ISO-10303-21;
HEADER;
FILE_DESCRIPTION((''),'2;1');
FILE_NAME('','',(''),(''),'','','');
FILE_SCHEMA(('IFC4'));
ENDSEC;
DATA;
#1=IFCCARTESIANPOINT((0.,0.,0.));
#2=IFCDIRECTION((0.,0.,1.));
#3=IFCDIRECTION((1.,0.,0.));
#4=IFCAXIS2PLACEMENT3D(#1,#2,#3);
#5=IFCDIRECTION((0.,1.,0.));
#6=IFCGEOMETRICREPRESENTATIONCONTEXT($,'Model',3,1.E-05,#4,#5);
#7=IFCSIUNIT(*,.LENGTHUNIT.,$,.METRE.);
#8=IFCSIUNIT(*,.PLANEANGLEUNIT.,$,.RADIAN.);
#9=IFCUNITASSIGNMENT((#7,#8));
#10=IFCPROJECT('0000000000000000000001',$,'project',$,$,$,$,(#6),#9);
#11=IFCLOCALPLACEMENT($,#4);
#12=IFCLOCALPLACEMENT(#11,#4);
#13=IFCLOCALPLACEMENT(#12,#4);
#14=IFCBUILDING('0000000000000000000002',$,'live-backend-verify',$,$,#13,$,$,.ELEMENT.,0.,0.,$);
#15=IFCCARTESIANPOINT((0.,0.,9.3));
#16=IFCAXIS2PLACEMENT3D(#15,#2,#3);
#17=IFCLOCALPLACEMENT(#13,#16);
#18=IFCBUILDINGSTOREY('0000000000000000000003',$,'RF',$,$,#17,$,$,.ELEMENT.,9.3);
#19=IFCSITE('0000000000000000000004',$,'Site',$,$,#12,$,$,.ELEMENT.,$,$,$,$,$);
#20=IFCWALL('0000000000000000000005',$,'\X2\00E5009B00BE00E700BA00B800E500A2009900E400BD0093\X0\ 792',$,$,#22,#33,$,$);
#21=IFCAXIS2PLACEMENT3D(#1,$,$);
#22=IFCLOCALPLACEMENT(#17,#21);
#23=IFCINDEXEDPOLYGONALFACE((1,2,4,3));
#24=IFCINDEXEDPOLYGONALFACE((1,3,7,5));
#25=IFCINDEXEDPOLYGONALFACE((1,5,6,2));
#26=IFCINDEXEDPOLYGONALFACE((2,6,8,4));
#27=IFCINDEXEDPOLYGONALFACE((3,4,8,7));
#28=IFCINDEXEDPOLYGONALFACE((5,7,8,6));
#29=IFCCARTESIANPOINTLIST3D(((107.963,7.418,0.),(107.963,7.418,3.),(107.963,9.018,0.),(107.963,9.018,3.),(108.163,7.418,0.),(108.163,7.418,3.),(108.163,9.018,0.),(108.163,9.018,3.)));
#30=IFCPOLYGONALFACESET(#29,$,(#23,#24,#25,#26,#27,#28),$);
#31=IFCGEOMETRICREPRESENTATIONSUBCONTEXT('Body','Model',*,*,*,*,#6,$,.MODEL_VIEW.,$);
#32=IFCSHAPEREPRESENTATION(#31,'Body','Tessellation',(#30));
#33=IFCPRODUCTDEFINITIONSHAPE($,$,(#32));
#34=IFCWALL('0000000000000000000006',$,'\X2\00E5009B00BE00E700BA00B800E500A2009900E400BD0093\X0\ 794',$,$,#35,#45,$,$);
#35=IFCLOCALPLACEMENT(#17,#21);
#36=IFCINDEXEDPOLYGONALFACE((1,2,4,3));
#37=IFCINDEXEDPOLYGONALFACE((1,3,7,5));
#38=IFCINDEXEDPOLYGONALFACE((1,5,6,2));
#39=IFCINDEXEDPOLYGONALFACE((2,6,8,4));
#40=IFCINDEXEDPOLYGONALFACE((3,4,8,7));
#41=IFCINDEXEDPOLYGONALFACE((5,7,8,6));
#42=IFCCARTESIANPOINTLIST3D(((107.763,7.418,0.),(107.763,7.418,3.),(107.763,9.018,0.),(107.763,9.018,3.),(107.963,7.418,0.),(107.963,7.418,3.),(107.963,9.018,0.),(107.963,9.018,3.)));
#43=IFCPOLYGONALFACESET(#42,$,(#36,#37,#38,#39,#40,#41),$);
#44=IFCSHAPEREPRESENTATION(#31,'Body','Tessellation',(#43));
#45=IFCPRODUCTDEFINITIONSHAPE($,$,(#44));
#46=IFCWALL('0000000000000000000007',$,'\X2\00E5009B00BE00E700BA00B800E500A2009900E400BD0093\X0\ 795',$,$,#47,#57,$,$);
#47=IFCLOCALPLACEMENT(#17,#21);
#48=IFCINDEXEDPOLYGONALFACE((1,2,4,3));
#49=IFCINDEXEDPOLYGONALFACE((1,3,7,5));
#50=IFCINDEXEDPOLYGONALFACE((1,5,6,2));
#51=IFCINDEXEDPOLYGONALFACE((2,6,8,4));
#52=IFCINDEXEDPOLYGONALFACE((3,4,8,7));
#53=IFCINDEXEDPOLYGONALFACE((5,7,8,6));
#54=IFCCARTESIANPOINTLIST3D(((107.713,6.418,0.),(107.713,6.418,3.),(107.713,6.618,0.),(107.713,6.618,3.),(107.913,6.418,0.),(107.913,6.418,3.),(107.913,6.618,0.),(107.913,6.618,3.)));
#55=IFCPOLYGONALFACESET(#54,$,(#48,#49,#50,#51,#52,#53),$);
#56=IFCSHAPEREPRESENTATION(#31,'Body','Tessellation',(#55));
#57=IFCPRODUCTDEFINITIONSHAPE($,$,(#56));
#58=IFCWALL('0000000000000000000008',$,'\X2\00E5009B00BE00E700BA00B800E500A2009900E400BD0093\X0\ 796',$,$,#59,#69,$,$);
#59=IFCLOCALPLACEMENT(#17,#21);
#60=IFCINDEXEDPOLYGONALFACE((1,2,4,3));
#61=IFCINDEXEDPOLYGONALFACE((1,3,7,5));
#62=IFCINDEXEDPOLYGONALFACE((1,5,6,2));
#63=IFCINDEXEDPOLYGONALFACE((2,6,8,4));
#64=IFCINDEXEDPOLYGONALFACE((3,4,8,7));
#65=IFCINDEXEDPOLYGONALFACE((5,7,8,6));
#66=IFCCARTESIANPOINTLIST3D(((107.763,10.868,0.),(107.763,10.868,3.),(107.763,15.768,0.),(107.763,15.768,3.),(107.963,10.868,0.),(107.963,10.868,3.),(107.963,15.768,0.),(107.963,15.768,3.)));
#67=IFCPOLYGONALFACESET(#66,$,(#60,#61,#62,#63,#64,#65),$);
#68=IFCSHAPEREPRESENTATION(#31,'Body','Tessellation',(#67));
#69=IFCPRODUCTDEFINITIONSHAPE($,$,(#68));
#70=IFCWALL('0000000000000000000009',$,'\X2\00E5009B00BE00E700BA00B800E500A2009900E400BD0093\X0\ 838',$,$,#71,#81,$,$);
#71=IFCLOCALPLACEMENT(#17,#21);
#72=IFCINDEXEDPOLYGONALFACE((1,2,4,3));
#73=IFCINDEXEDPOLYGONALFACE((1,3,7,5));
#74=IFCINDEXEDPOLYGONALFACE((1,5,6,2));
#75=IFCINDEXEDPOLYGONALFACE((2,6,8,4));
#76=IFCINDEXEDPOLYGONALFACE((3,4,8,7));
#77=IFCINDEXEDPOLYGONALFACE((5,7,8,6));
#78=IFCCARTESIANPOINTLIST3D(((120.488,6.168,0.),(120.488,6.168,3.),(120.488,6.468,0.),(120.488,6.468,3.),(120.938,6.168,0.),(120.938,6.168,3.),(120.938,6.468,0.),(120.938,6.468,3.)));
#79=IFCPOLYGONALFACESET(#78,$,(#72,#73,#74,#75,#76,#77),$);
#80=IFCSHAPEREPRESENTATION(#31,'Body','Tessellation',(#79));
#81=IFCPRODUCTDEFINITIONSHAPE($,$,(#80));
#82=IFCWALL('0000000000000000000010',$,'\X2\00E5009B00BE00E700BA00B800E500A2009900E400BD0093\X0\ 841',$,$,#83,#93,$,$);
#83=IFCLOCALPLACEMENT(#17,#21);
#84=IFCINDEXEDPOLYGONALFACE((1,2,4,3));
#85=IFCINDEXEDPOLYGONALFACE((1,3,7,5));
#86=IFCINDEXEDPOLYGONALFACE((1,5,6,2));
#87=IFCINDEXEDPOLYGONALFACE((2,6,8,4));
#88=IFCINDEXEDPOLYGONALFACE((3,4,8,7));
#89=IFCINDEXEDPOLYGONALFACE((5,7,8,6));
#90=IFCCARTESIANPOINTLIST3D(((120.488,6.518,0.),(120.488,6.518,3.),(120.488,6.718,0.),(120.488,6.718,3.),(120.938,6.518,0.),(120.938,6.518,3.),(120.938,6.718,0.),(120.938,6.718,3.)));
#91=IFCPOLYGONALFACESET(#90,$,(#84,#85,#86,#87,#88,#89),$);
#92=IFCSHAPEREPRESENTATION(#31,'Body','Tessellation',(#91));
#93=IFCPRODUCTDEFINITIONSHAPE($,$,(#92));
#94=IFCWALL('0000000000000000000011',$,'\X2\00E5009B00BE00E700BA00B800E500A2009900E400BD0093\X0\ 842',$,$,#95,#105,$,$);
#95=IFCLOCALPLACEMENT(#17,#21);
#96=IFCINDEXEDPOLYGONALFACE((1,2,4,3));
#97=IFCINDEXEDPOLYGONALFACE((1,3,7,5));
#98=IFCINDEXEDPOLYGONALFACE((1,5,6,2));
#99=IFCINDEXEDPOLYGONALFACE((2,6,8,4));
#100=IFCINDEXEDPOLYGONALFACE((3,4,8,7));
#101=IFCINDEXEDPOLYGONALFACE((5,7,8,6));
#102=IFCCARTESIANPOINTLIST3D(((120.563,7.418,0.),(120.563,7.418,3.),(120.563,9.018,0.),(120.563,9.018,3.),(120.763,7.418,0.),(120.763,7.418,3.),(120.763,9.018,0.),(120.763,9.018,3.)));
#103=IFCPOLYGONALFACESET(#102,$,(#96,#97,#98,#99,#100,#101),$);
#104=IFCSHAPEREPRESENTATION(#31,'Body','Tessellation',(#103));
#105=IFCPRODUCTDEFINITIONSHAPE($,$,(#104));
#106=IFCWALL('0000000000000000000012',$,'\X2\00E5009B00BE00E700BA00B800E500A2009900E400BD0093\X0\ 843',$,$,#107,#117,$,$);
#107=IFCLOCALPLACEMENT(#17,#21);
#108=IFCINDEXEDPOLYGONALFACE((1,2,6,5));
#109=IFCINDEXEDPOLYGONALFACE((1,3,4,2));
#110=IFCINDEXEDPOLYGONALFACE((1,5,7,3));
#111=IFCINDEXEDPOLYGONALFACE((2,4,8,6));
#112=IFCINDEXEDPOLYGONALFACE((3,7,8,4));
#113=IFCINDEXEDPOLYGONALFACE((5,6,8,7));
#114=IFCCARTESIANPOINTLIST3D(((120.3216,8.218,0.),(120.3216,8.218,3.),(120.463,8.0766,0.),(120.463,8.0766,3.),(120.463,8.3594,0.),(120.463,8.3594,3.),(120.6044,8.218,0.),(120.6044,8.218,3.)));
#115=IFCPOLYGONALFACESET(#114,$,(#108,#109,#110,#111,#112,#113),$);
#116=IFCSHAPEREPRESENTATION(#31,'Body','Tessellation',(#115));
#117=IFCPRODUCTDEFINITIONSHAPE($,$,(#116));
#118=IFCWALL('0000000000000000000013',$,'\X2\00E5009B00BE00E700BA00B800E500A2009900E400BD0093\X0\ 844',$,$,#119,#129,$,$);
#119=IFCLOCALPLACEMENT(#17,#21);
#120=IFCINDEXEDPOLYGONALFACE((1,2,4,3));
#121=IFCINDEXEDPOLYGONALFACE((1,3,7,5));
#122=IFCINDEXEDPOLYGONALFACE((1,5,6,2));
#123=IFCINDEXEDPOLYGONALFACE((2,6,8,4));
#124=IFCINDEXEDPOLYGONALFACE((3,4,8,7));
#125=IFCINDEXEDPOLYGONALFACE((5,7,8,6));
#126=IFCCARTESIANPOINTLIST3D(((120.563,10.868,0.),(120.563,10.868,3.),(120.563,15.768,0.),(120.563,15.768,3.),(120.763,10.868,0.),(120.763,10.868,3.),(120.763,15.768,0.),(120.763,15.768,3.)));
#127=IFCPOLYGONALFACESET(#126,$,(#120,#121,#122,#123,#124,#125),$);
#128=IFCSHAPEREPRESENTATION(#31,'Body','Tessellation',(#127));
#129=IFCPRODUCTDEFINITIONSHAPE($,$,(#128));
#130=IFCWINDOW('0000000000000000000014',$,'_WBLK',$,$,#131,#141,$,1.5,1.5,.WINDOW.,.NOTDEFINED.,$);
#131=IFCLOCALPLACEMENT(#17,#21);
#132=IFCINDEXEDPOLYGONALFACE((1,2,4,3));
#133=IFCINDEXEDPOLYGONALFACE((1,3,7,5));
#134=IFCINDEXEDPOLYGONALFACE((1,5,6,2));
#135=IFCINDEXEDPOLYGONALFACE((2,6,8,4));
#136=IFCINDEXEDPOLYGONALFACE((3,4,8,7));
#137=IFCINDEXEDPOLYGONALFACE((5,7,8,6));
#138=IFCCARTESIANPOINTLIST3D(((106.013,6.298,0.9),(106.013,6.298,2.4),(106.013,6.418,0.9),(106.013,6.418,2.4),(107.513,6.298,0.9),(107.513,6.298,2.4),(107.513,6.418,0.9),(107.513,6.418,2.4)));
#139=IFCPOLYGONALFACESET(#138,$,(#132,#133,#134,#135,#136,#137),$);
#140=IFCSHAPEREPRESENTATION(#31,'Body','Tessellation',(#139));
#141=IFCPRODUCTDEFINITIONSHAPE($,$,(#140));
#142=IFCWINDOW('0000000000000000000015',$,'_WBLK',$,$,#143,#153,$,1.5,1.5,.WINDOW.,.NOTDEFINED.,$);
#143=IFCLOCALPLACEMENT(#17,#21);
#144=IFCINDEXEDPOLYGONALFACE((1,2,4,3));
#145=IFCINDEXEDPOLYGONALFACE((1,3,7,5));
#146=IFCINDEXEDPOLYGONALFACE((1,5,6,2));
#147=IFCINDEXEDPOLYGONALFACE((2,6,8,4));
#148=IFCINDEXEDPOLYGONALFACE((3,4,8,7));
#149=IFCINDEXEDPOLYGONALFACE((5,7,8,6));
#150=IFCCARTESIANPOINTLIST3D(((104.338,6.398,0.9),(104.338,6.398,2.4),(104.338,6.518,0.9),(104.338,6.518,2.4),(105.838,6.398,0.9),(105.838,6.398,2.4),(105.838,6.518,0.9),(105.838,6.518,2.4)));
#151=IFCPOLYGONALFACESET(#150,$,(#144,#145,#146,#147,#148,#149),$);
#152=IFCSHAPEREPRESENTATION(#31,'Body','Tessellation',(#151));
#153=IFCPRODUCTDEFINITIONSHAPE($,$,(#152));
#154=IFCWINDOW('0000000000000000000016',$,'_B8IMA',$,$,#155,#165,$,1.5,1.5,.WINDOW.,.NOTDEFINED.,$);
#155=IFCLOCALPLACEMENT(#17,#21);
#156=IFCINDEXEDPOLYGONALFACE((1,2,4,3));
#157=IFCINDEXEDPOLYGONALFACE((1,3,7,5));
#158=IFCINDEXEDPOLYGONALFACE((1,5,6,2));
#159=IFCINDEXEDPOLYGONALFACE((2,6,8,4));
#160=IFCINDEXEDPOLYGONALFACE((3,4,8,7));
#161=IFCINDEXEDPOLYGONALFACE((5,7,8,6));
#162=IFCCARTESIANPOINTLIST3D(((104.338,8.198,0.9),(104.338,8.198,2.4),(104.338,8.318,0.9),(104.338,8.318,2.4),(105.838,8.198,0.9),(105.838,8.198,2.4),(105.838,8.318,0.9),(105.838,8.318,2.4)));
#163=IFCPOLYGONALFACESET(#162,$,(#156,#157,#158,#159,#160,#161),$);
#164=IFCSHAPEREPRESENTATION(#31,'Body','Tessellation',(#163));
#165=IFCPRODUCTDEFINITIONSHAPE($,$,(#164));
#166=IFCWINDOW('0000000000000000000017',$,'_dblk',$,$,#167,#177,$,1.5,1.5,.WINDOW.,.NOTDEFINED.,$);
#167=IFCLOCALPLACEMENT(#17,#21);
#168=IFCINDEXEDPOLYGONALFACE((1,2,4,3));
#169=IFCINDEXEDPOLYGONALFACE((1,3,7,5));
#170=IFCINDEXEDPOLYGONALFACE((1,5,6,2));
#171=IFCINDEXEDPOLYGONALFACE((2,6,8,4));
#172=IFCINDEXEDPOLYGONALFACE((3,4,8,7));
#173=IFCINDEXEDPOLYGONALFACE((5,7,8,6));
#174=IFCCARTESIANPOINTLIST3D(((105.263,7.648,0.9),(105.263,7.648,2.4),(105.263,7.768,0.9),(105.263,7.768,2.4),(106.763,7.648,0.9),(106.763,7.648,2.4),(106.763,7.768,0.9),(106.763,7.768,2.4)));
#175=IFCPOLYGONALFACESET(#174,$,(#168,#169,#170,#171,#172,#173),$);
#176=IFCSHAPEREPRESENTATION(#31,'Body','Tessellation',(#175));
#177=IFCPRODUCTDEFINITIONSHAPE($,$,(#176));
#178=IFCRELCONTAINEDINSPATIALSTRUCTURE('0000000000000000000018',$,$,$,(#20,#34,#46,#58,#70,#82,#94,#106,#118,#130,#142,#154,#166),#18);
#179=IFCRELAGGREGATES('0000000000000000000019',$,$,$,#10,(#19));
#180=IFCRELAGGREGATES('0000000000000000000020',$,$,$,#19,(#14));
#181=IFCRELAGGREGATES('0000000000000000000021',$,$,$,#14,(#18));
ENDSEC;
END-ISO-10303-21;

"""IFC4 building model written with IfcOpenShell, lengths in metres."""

from ifc_helpers import new_model, si_unit, direction, frame, frame_2d, origin_with_axes, place, context, subcontext, project, spatial, rectangle, extrude, element, save


model = new_model("IFC4")

# Units and contexts
model_context = context("Model", 3, precision=1e-05, world=origin_with_axes(), true_north=direction((0.0, 1.0, 0.0)))
body_context = subcontext(model_context, "Body", "Model", "MODEL_VIEW")
ifc_project = project(units=[si_unit("LENGTHUNIT", "METRE"), si_unit("PLANEANGLEUNIT", "RADIAN")], contexts=[model_context])

# Site, building, storey
placement = place(None, origin_with_axes())
site_placement = place(placement, origin_with_axes())
site = spatial("IfcSite", under=ifc_project, at=site_placement, Name="Site", CompositionType="ELEMENT")
building_placement = place(site_placement, origin_with_axes())
building = spatial("IfcBuilding", under=site, at=building_placement, Name="live-backend-verify", CompositionType="ELEMENT", ElevationOfRefHeight=0.0, ElevationOfTerrain=0.0)
storey_placement = place(building_placement, frame((0.0, 0.0, 9.3), z_axis=(0.0, 0.0, 1.0), x_axis=(1.0, 0.0, 0.0)))
storey = spatial("IfcBuildingStorey", under=building, at=storey_placement, Name="RF", CompositionType="ELEMENT", Elevation=9.3)

# Walls
for number, where, z_axis, x_axis, name in (
    (1, (108.063, 8.218, 0.0), (0.0, 0.0, 1.0), (0.0, -1.0, 0.0), "å\u009b¾çº¸å¢\u0099ä½\u0093 792"),
    (2, (107.863, 8.218, 0.0), (0.0, 0.0, 1.0), (0.0, -1.0, 0.0), "å\u009b¾çº¸å¢\u0099ä½\u0093 794"),
):
    element("IfcWall", number, at=place(storey_placement, frame(where, z_axis=z_axis, x_axis=x_axis)), inside=storey, Name=name, context=body_context, shape_type="SweptSolid", body=[
        extrude(rectangle(XDim=1.6, YDim=0.2, at=frame_2d((0.0, 0.0), x_axis=(1.0, 0.0, 0.0))), frame((0.0, 0.0, 0.0), z_axis=(0.0, 0.0, 1.0)), (0.0, 0.0, 1.0), 3.0),
    ])
wall_1_placement = place(storey_placement, frame((107.813, 6.518, 0.0), z_axis=(0.0, 0.0, 1.0), x_axis=(0.0, -1.0, 0.0)))
element("IfcWall", 3, at=wall_1_placement, inside=storey, Name="å\u009b¾çº¸å¢\u0099ä½\u0093 795", context=body_context, shape_type="SweptSolid", body=[
    extrude(rectangle(XDim=0.2, YDim=0.2, at=frame_2d((0.0, 0.0), x_axis=(1.0, 0.0, 0.0))), frame((0.0, 0.0, 0.0), z_axis=(0.0, 0.0, 1.0)), (0.0, 0.0, 1.0), 3.0),
])
wall_2_placement = place(storey_placement, frame((107.863, 13.318, 0.0), z_axis=(0.0, 0.0, 1.0), x_axis=(0.0, -1.0, 0.0)))
element("IfcWall", 4, at=wall_2_placement, inside=storey, Name="å\u009b¾çº¸å¢\u0099ä½\u0093 796", context=body_context, shape_type="SweptSolid", body=[
    extrude(rectangle(XDim=4.9, YDim=0.2, at=frame_2d((0.0, 0.0), x_axis=(1.0, 0.0, 0.0))), frame((0.0, 0.0, 0.0), z_axis=(0.0, 0.0, 1.0)), (0.0, 0.0, 1.0), 3.0),
])
wall_3_placement = place(storey_placement, frame((120.713, 6.318, 0.0), z_axis=(0.0, 0.0, 1.0), x_axis=(1.0, 0.0, 0.0)))
element("IfcWall", 5, at=wall_3_placement, inside=storey, Name="å\u009b¾çº¸å¢\u0099ä½\u0093 838", context=body_context, shape_type="SweptSolid", body=[
    extrude(rectangle(XDim=0.45, YDim=0.3, at=frame_2d((0.0, 0.0), x_axis=(1.0, 0.0, 0.0))), frame((0.0, 0.0, 0.0), z_axis=(0.0, 0.0, 1.0)), (0.0, 0.0, 1.0), 3.0),
])
wall_4_placement = place(storey_placement, frame((120.713, 6.618, 0.0), z_axis=(0.0, 0.0, 1.0), x_axis=(1.0, 0.0, 0.0)))
element("IfcWall", 6, at=wall_4_placement, inside=storey, Name="å\u009b¾çº¸å¢\u0099ä½\u0093 841", context=body_context, shape_type="SweptSolid", body=[
    extrude(rectangle(XDim=0.45, YDim=0.2, at=frame_2d((0.0, 0.0), x_axis=(1.0, 0.0, 0.0))), frame((0.0, 0.0, 0.0), z_axis=(0.0, 0.0, 1.0)), (0.0, 0.0, 1.0), 3.0),
])
wall_5_placement = place(storey_placement, frame((120.663, 8.218, 0.0), z_axis=(0.0, 0.0, 1.0), x_axis=(0.0, -1.0, 0.0)))
element("IfcWall", 7, at=wall_5_placement, inside=storey, Name="å\u009b¾çº¸å¢\u0099ä½\u0093 842", context=body_context, shape_type="SweptSolid", body=[
    extrude(rectangle(XDim=1.6, YDim=0.2, at=frame_2d((0.0, 0.0), x_axis=(1.0, 0.0, 0.0))), frame((0.0, 0.0, 0.0), z_axis=(0.0, 0.0, 1.0)), (0.0, 0.0, 1.0), 3.0),
])
wall_6_placement = place(storey_placement, frame((120.463, 8.218, 0.0), z_axis=(0.0, 0.0, 1.0), x_axis=(0.707107, -0.707107, 0.0)))
element("IfcWall", 8, at=wall_6_placement, inside=storey, Name="å\u009b¾çº¸å¢\u0099ä½\u0093 843", context=body_context, shape_type="SweptSolid", body=[
    extrude(rectangle(XDim=0.2, YDim=0.2, at=frame_2d((0.0, 0.0), x_axis=(1.0, 0.0, 0.0))), frame((0.0, 0.0, 0.0), z_axis=(0.0, 0.0, 1.0)), (0.0, 0.0, 1.0), 3.0),
])
wall_7_placement = place(storey_placement, frame((120.663, 13.318, 0.0), z_axis=(0.0, 0.0, 1.0), x_axis=(0.0, -1.0, 0.0)))
element("IfcWall", 9, at=wall_7_placement, inside=storey, Name="å\u009b¾çº¸å¢\u0099ä½\u0093 844", context=body_context, shape_type="SweptSolid", body=[
    extrude(rectangle(XDim=4.9, YDim=0.2, at=frame_2d((0.0, 0.0), x_axis=(1.0, 0.0, 0.0))), frame((0.0, 0.0, 0.0), z_axis=(0.0, 0.0, 1.0)), (0.0, 0.0, 1.0), 3.0),
])

# Windows
for number, where, z_axis, x_axis, name in (
    (10, (106.763, 6.358, 0.9), (0.0, 0.0, 1.0), (1.0, 0.0, 0.0), "_WBLK"),
    (11, (105.088, 6.458, 0.9), (0.0, 0.0, 1.0), (1.0, 0.0, 0.0), "_WBLK"),
    (12, (105.088, 8.258, 0.9), (0.0, 0.0, 1.0), (1.0, 0.0, 0.0), "_B8IMA"),
    (13, (106.013, 7.708, 0.9), (0.0, 0.0, 1.0), (1.0, 0.0, 0.0), "_dblk"),
):
    element("IfcWindow", number, at=place(storey_placement, frame(where, z_axis=z_axis, x_axis=x_axis)), inside=storey, Name=name, OverallHeight=1.5, OverallWidth=1.5, PartitioningType="NOTDEFINED", PredefinedType="WINDOW", context=body_context, shape_type="SweptSolid", body=[
        extrude(rectangle(XDim=1.5, YDim=0.12, at=frame_2d((0.0, 0.0), x_axis=(1.0, 0.0, 0.0))), frame((0.0, 0.0, 0.0), z_axis=(0.0, 0.0, 1.0)), (0.0, 0.0, 1.0), 1.5),
    ])

save(model, "model.ifc")
